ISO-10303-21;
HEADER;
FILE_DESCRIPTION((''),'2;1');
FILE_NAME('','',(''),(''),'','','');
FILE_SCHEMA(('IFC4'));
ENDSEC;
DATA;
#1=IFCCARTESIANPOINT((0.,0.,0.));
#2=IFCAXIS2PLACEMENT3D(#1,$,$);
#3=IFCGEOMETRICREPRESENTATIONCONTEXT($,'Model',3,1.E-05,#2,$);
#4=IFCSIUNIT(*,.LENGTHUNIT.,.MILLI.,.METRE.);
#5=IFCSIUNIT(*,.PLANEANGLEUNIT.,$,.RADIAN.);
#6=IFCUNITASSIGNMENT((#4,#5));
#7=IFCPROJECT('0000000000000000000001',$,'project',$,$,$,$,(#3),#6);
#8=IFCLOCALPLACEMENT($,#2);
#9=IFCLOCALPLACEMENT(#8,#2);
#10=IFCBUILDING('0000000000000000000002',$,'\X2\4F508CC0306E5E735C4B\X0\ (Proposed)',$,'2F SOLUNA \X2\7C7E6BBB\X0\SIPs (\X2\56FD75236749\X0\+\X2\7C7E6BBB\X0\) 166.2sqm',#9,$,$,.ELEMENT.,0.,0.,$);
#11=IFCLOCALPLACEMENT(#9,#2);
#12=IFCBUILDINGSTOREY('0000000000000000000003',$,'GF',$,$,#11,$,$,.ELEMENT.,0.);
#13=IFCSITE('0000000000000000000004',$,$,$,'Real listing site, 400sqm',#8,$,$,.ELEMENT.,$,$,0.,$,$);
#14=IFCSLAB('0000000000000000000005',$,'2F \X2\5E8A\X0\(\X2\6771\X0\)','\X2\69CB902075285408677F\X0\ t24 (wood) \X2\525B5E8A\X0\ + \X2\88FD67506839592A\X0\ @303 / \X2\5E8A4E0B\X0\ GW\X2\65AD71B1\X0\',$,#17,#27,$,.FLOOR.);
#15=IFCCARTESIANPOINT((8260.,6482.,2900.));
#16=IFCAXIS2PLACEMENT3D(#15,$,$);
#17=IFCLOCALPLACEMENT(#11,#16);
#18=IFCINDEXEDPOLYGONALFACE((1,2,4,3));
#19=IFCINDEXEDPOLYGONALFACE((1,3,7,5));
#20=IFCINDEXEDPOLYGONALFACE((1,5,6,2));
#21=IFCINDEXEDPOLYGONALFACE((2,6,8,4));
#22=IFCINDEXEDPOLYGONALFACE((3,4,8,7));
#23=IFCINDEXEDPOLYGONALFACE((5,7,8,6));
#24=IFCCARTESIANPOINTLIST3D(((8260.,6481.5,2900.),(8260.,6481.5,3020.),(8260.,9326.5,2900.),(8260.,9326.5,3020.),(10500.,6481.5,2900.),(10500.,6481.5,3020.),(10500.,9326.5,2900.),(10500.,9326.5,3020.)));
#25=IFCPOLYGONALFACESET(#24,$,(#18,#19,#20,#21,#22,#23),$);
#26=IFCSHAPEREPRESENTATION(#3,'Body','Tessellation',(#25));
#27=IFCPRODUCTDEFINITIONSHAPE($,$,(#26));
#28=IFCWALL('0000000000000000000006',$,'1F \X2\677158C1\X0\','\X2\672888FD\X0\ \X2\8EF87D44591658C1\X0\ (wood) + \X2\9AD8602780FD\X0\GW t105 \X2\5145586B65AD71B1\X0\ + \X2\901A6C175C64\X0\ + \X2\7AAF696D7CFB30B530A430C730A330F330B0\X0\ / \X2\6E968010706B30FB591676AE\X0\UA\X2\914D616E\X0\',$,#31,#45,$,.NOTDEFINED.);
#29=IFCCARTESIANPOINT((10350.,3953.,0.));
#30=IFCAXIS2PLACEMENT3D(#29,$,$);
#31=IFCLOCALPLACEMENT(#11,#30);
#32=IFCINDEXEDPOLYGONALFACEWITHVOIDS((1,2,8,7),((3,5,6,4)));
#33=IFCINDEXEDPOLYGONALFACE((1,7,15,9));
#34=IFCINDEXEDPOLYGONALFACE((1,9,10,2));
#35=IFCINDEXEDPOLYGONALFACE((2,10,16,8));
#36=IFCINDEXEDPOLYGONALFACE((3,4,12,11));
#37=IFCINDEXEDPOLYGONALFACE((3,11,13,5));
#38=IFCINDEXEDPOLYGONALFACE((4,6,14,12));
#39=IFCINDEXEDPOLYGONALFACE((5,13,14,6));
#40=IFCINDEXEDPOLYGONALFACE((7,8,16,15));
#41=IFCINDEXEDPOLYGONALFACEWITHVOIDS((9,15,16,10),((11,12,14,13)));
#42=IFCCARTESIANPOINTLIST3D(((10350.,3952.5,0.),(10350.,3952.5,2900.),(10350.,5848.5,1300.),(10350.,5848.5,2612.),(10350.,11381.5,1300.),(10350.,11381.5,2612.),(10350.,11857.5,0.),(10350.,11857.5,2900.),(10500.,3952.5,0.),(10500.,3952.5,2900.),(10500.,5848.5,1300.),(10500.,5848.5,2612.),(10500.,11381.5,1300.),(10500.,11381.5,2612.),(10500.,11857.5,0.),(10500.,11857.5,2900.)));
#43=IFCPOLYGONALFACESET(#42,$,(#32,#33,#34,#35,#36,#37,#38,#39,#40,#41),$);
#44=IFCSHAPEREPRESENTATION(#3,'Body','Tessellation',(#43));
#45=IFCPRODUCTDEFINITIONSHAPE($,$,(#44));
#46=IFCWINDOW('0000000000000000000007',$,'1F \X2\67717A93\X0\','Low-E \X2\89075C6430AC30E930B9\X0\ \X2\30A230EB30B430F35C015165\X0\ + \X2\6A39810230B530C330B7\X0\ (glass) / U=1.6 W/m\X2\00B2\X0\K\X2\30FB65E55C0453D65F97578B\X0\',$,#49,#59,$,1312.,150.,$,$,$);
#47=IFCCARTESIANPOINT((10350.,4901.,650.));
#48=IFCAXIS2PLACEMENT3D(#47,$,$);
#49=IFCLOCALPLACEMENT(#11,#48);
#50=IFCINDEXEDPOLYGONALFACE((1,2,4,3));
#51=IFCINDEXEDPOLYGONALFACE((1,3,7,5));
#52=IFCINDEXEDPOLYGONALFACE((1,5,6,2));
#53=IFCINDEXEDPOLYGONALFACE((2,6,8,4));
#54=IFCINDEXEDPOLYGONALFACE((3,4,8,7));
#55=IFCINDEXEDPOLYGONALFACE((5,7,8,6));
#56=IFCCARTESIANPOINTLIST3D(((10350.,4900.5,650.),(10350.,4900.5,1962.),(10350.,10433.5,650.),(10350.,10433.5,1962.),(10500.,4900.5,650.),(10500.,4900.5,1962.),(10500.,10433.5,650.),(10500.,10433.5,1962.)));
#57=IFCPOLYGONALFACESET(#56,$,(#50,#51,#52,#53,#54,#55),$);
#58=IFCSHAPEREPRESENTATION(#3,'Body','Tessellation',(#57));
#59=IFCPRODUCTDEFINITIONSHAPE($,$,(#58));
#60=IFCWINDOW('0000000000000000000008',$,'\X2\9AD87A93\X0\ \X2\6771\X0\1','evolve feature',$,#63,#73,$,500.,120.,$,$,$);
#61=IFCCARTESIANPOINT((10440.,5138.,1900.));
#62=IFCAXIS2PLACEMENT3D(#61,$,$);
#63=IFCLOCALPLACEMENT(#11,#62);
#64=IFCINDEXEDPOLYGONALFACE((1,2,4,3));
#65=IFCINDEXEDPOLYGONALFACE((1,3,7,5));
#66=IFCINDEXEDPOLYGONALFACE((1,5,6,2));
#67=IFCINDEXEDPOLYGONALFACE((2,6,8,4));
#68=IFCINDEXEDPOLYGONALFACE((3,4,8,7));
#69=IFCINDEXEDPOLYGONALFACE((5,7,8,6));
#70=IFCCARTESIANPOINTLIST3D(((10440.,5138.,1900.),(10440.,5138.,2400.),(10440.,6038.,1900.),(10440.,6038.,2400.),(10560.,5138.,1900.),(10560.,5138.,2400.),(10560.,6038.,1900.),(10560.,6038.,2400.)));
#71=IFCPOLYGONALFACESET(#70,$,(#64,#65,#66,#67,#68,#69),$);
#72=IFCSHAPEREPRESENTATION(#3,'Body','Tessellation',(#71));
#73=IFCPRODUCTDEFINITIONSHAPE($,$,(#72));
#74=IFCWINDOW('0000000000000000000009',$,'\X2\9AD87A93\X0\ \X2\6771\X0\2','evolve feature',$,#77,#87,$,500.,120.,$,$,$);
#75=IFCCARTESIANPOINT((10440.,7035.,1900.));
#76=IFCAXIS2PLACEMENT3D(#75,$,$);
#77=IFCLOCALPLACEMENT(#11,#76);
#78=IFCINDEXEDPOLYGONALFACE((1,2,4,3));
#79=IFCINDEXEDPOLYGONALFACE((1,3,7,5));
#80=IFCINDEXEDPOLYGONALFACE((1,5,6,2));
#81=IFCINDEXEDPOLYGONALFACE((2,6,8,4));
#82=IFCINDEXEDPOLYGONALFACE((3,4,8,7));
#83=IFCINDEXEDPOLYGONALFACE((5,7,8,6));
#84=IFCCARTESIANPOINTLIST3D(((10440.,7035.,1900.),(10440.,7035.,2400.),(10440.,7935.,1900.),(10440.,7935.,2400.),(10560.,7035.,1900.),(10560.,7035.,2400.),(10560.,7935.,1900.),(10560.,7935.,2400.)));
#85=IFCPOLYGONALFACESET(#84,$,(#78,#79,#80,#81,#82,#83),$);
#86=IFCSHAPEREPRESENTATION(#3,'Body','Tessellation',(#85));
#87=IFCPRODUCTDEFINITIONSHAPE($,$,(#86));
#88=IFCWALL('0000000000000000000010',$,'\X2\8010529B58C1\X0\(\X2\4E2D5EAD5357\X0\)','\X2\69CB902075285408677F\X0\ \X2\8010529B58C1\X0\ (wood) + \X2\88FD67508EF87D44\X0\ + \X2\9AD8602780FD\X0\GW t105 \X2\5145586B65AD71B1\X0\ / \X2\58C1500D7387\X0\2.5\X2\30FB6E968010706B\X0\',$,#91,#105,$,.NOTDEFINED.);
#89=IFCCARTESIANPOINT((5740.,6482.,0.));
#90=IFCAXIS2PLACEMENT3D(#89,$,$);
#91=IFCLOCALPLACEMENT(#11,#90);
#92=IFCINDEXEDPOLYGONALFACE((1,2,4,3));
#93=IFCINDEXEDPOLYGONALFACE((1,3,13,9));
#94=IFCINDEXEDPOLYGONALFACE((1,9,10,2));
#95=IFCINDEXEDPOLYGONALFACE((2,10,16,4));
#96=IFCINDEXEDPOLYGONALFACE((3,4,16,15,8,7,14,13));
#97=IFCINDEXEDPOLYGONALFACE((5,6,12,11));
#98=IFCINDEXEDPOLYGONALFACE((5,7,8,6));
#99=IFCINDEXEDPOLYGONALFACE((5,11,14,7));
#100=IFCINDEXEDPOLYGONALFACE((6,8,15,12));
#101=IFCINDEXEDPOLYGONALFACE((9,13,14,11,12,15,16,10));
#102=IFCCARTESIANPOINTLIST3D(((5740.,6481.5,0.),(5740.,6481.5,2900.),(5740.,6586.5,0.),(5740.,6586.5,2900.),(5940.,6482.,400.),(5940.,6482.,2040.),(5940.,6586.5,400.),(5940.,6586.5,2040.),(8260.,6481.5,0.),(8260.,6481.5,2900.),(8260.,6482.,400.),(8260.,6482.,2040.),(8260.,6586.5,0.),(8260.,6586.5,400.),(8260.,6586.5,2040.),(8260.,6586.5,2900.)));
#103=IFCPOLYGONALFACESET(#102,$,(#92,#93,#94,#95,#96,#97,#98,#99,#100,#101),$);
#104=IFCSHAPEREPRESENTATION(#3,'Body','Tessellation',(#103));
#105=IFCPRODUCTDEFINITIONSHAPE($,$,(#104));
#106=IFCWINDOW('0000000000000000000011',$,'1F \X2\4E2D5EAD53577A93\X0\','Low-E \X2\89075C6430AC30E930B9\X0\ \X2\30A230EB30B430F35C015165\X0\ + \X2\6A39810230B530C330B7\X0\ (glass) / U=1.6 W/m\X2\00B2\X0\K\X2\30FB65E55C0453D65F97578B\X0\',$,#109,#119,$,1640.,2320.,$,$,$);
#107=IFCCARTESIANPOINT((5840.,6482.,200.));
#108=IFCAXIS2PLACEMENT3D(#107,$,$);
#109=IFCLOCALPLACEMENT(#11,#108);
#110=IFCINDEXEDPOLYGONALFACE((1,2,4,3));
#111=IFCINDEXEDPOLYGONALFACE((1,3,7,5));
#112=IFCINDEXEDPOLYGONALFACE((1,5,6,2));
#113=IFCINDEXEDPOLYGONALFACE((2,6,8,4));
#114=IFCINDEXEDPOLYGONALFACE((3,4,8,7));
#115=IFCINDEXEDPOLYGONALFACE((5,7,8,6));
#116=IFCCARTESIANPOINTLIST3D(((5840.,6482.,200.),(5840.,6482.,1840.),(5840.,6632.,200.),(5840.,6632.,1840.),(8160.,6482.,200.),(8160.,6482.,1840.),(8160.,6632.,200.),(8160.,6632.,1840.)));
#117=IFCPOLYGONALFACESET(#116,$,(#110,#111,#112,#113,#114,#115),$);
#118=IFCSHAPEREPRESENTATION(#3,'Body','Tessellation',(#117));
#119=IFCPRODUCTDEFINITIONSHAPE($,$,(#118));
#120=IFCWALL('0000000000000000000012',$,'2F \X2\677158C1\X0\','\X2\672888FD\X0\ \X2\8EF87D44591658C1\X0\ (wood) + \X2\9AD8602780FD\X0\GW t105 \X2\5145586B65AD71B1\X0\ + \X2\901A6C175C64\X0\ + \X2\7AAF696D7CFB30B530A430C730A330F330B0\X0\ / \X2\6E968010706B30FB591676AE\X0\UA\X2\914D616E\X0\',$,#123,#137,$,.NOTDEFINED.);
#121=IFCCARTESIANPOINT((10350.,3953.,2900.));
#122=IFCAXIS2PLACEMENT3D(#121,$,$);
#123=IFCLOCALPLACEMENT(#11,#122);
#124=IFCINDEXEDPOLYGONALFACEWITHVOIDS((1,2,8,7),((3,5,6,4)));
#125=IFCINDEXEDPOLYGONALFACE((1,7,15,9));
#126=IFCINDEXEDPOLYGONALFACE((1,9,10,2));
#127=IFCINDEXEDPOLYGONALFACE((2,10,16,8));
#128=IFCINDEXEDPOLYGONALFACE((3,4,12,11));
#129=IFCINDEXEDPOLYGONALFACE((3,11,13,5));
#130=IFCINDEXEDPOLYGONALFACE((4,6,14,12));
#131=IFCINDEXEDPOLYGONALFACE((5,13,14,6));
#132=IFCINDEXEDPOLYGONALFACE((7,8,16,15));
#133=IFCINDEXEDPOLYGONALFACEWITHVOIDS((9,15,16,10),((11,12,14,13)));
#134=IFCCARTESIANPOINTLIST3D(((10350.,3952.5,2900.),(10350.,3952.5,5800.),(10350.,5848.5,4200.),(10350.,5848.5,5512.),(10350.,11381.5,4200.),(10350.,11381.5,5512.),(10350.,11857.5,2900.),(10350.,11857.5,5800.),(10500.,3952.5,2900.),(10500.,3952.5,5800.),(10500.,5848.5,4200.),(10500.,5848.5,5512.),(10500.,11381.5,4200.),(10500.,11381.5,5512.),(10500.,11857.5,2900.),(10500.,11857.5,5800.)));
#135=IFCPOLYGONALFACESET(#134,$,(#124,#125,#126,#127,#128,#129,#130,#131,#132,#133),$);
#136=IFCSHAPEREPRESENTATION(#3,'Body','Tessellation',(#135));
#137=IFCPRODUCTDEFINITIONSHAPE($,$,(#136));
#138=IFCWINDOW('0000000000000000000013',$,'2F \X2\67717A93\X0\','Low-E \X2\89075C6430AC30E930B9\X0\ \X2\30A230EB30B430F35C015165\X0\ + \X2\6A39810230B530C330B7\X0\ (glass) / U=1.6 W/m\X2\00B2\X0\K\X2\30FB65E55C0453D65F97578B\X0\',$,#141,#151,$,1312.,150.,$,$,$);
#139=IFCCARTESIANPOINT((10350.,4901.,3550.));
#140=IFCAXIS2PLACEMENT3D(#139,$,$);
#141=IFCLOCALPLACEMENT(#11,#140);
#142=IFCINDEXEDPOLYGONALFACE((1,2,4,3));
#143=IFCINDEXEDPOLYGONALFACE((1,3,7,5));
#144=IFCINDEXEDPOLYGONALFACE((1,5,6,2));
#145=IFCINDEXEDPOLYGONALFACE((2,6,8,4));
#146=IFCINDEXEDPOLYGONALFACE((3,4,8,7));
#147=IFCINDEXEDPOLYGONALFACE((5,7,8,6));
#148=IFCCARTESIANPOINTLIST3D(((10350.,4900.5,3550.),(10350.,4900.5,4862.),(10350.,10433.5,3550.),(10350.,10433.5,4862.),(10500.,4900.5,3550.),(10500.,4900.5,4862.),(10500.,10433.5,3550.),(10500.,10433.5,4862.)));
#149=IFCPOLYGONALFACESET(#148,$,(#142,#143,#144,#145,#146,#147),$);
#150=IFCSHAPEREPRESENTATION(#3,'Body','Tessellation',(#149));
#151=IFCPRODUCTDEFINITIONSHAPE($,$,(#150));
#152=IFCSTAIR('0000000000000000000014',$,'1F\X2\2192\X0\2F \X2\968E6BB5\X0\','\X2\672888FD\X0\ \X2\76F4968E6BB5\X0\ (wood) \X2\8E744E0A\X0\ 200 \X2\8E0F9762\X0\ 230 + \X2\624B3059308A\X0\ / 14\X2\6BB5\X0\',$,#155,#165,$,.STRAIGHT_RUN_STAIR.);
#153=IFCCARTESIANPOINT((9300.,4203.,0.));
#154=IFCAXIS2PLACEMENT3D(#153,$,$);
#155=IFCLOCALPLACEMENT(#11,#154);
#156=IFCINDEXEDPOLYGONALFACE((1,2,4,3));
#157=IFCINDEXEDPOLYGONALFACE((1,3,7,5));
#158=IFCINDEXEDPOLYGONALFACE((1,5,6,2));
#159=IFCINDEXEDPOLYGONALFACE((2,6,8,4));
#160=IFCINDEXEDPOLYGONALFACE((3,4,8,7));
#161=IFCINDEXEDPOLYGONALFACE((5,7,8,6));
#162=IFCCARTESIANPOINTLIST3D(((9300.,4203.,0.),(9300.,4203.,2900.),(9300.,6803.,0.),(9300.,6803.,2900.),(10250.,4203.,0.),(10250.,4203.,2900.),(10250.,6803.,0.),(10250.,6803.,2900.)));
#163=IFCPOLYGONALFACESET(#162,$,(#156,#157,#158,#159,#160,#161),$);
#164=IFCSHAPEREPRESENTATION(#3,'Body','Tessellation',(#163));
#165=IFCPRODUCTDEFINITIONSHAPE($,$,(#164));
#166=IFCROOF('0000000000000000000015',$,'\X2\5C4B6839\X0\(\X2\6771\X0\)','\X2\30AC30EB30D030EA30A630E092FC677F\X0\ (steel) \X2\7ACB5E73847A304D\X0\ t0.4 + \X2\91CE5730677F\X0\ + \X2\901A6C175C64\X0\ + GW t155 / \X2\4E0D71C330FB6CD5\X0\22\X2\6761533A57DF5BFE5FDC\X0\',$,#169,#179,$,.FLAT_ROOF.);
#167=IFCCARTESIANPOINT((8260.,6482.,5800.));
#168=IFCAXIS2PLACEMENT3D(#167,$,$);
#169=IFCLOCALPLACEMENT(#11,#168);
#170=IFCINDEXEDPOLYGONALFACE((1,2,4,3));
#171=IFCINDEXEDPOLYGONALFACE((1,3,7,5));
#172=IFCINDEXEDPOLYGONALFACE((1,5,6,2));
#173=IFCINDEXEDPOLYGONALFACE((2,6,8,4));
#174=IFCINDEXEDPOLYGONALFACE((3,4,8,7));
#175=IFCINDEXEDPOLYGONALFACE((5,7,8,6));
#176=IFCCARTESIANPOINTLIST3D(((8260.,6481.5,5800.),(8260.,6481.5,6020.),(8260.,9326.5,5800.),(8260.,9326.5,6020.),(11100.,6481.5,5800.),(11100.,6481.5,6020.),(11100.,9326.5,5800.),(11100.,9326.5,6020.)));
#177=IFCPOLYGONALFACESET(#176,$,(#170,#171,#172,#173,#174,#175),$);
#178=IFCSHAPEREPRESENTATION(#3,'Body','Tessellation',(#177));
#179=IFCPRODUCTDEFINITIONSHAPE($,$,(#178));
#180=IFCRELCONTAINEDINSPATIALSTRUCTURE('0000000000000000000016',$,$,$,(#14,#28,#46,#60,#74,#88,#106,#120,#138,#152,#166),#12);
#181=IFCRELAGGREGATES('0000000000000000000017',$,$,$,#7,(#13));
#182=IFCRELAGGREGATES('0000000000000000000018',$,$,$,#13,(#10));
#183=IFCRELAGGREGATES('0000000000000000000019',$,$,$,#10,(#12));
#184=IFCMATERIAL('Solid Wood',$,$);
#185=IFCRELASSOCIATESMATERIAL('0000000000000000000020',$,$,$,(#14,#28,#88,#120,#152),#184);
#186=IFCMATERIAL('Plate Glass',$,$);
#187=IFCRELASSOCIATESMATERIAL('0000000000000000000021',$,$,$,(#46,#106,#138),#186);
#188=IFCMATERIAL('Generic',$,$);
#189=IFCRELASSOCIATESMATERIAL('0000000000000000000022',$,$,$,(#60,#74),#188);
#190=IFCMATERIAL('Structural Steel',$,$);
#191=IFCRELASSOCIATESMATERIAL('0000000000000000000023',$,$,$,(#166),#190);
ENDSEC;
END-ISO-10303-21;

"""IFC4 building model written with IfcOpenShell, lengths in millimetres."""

from ifc_helpers import new_model, si_unit, frame, frame_2d, origin, place, context, project, spatial, rectangle, extrude, material, element, fill, save


model = new_model("IFC4")

# Units and contexts
model_context = context("Model", 3, precision=1e-05, world=origin())
ifc_project = project(units=[si_unit("LENGTHUNIT", "METRE", prefix="MILLI"), si_unit("PLANEANGLEUNIT", "RADIAN")], contexts=[model_context])

# Site, building, storey
site_placement = place(None, origin())
site = spatial("IfcSite", under=ifc_project, at=site_placement, ObjectType="Real listing site, 400sqm", CompositionType="ELEMENT", RefElevation=0.0)
building_placement = place(site_placement, origin())
building = spatial("IfcBuilding", under=site, at=building_placement, Name="佐賀の平屋 (Proposed)", ObjectType="2F SOLUNA 籾殻SIPs (国産杉+籾殻) 166.2sqm", CompositionType="ELEMENT", ElevationOfRefHeight=0.0, ElevationOfTerrain=0.0)
storey_placement = place(building_placement, origin())
storey = spatial("IfcBuildingStorey", under=building, at=storey_placement, Name="GF", CompositionType="ELEMENT", Elevation=0.0)

# Slab
ifc_material_1 = material(Name="Solid Wood")
slab_1_placement = place(storey_placement, frame((8260.0, 6482.0, 2900.0)))
element("IfcSlab", 1, at=slab_1_placement, inside=storey, material=ifc_material_1, Name="2F 床(東)", Description="構造用合板 t24 (wood) 剛床 + 製材根太 @303 / 床下 GW断熱", PredefinedType="FLOOR", context=model_context, shape_type="SweptSolid", body=[
    extrude(rectangle(XDim=2240.0, YDim=2845.0, at=frame_2d((1120.0, 1422.0))), frame((8260.0, 6482.0, 2900.0)), (0.0, 0.0, 1.0), 120.0),
])

# Wall, openings, windows
wall_1_placement = place(storey_placement, frame((10350.0, 3953.0, 0.0)))
wall_1 = element("IfcWall", 2, at=wall_1_placement, inside=storey, material=ifc_material_1, Name="1F 東壁", Description="木製 軸組外壁 (wood) + 高性能GW t105 充填断熱 + 通気層 + 窯業系サイディング / 準耐火・外皮UA配慮", PredefinedType="NOTDEFINED", context=model_context, shape_type="SweptSolid", body=[
    extrude(rectangle(XDim=150.0, YDim=7905.0, at=frame_2d((75.0, 3952.0))), frame((10350.0, 3953.0, 0.0)), (0.0, 0.0, 1.0), 2900.0),
])
opening_1_placement = place(storey_placement, frame((10350.0, 4901.0, 650.0)))
opening_1 = element("IfcOpeningElement", 3, at=opening_1_placement, cuts=wall_1, PredefinedType="NOTDEFINED", context=model_context, shape_type="SweptSolid", body=[
    extrude(rectangle(XDim=150.0, YDim=5533.0, at=frame_2d((75.0, 2766.0))), frame((10350.0, 4901.0, 650.0)), (0.0, 0.0, 1.0), 1312.0),
])
opening_2_placement = place(storey_placement, frame((10440.0, 5138.0, 1900.0)))
opening_2 = element("IfcOpeningElement", 4, at=opening_2_placement, cuts=wall_1, PredefinedType="NOTDEFINED", context=model_context, shape_type="SweptSolid", body=[
    extrude(rectangle(XDim=120.0, YDim=900.0, at=frame_2d((60.0, 450.0))), frame((10440.0, 5138.0, 1900.0)), (0.0, 0.0, 1.0), 500.0),
])
opening_3_placement = place(storey_placement, frame((10440.0, 7035.0, 1900.0)))
opening_3 = element("IfcOpeningElement", 5, at=opening_3_placement, cuts=wall_1, PredefinedType="NOTDEFINED", context=model_context, shape_type="SweptSolid", body=[
    extrude(rectangle(XDim=120.0, YDim=900.0, at=frame_2d((60.0, 450.0))), frame((10440.0, 7035.0, 1900.0)), (0.0, 0.0, 1.0), 500.0),
])
ifc_material_2 = material(Name="Plate Glass")
window_1_placement = place(storey_placement, frame((10350.0, 4901.0, 650.0)))
window_1 = element("IfcWindow", 6, at=window_1_placement, inside=storey, material=ifc_material_2, Name="1F 東窓", Description="Low-E 複層ガラス アルゴン封入 + 樹脂サッシ (glass) / U=1.6 W/m²K・日射取得型", OverallHeight=1312.0, OverallWidth=150.0, context=model_context, shape_type="SweptSolid", body=[
    extrude(rectangle(XDim=150.0, YDim=5533.0, at=frame_2d((75.0, 2766.0))), frame((10350.0, 4901.0, 650.0)), (0.0, 0.0, 1.0), 1312.0),
])
fill(opening_1, window_1)
ifc_material_3 = material(Name="Generic")
window_2_placement = place(storey_placement, frame((10440.0, 5138.0, 1900.0)))
window_2 = element("IfcWindow", 7, at=window_2_placement, inside=storey, material=ifc_material_3, Name="高窓 東1", Description="evolve feature", OverallHeight=500.0, OverallWidth=120.0, context=model_context, shape_type="SweptSolid", body=[
    extrude(rectangle(XDim=120.0, YDim=900.0, at=frame_2d((60.0, 450.0))), frame((10440.0, 5138.0, 1900.0)), (0.0, 0.0, 1.0), 500.0),
])
fill(opening_2, window_2)
window_3_placement = place(storey_placement, frame((10440.0, 7035.0, 1900.0)))
window_3 = element("IfcWindow", 8, at=window_3_placement, inside=storey, material=ifc_material_3, Name="高窓 東2", Description="evolve feature", OverallHeight=500.0, OverallWidth=120.0, context=model_context, shape_type="SweptSolid", body=[
    extrude(rectangle(XDim=120.0, YDim=900.0, at=frame_2d((60.0, 450.0))), frame((10440.0, 7035.0, 1900.0)), (0.0, 0.0, 1.0), 500.0),
])
fill(opening_3, window_3)

# Wall, opening, window
wall_2_placement = place(storey_placement, frame((5740.0, 6482.0, 0.0)))
wall_2 = element("IfcWall", 9, at=wall_2_placement, inside=storey, material=ifc_material_1, Name="耐力壁(中庭南)", Description="構造用合板 耐力壁 (wood) + 製材軸組 + 高性能GW t105 充填断熱 / 壁倍率2.5・準耐火", PredefinedType="NOTDEFINED", context=model_context, shape_type="SweptSolid", body=[
    extrude(rectangle(XDim=2520.0, YDim=105.0, at=frame_2d((1260.0, 52.0))), frame((5740.0, 6482.0, 0.0)), (0.0, 0.0, 1.0), 2900.0),
])
opening_4_placement = place(storey_placement, frame((5840.0, 6482.0, 200.0)))
opening_4 = element("IfcOpeningElement", 10, at=opening_4_placement, cuts=wall_2, PredefinedType="NOTDEFINED", context=model_context, shape_type="SweptSolid", body=[
    extrude(rectangle(XDim=2320.0, YDim=150.0, at=frame_2d((1160.0, 75.0))), frame((5840.0, 6482.0, 200.0)), (0.0, 0.0, 1.0), 1640.0),
])
window_4_placement = place(storey_placement, frame((5840.0, 6482.0, 200.0)))
window_4 = element("IfcWindow", 11, at=window_4_placement, inside=storey, material=ifc_material_2, Name="1F 中庭南窓", Description="Low-E 複層ガラス アルゴン封入 + 樹脂サッシ (glass) / U=1.6 W/m²K・日射取得型", OverallHeight=1640.0, OverallWidth=2320.0, context=model_context, shape_type="SweptSolid", body=[
    extrude(rectangle(XDim=2320.0, YDim=150.0, at=frame_2d((1160.0, 75.0))), frame((5840.0, 6482.0, 200.0)), (0.0, 0.0, 1.0), 1640.0),
])
fill(opening_4, window_4)

# Wall, opening, window
wall_3_placement = place(storey_placement, frame((10350.0, 3953.0, 2900.0)))
wall_3 = element("IfcWall", 12, at=wall_3_placement, inside=storey, material=ifc_material_1, Name="2F 東壁", Description="木製 軸組外壁 (wood) + 高性能GW t105 充填断熱 + 通気層 + 窯業系サイディング / 準耐火・外皮UA配慮", PredefinedType="NOTDEFINED", context=model_context, shape_type="SweptSolid", body=[
    extrude(rectangle(XDim=150.0, YDim=7905.0, at=frame_2d((75.0, 3952.0))), frame((10350.0, 3953.0, 2900.0)), (0.0, 0.0, 1.0), 2900.0),
])
opening_5_placement = place(storey_placement, frame((10350.0, 4901.0, 3550.0)))
opening_5 = element("IfcOpeningElement", 13, at=opening_5_placement, cuts=wall_3, PredefinedType="NOTDEFINED", context=model_context, shape_type="SweptSolid", body=[
    extrude(rectangle(XDim=150.0, YDim=5533.0, at=frame_2d((75.0, 2766.0))), frame((10350.0, 4901.0, 3550.0)), (0.0, 0.0, 1.0), 1312.0),
])
window_5_placement = place(storey_placement, frame((10350.0, 4901.0, 3550.0)))
window_5 = element("IfcWindow", 14, at=window_5_placement, inside=storey, material=ifc_material_2, Name="2F 東窓", Description="Low-E 複層ガラス アルゴン封入 + 樹脂サッシ (glass) / U=1.6 W/m²K・日射取得型", OverallHeight=1312.0, OverallWidth=150.0, context=model_context, shape_type="SweptSolid", body=[
    extrude(rectangle(XDim=150.0, YDim=5533.0, at=frame_2d((75.0, 2766.0))), frame((10350.0, 4901.0, 3550.0)), (0.0, 0.0, 1.0), 1312.0),
])
fill(opening_5, window_5)

# Stair
stair_placement = place(storey_placement, frame((9300.0, 4203.0, 0.0)))
element("IfcStair", 15, at=stair_placement, inside=storey, material=ifc_material_1, Name="1F→2F 階段", Description="木製 直階段 (wood) 蹴上 200 踏面 230 + 手すり / 14段", PredefinedType="STRAIGHT_RUN_STAIR", context=model_context, shape_type="SweptSolid", body=[
    extrude(rectangle(XDim=950.0, YDim=2600.0, at=frame_2d((475.0, 1300.0))), frame((9300.0, 4203.0, 0.0)), (0.0, 0.0, 1.0), 2900.0),
])

# Roof
ifc_material_4 = material(Name="Structural Steel")
roof_placement = place(storey_placement, frame((8260.0, 6482.0, 5800.0)))
element("IfcRoof", 16, at=roof_placement, inside=storey, material=ifc_material_4, Name="屋根(東)", Description="ガルバリウム鋼板 (steel) 立平葺き t0.4 + 野地板 + 通気層 + GW t155 / 不燃・法22条区域対応", PredefinedType="FLAT_ROOF", context=model_context, shape_type="SweptSolid", body=[
    extrude(rectangle(XDim=2840.0, YDim=2845.0, at=frame_2d((1420.0, 1422.0))), frame((8260.0, 6482.0, 5800.0)), (0.0, 0.0, 1.0), 220.0),
])

save(model, "model.ifc")
